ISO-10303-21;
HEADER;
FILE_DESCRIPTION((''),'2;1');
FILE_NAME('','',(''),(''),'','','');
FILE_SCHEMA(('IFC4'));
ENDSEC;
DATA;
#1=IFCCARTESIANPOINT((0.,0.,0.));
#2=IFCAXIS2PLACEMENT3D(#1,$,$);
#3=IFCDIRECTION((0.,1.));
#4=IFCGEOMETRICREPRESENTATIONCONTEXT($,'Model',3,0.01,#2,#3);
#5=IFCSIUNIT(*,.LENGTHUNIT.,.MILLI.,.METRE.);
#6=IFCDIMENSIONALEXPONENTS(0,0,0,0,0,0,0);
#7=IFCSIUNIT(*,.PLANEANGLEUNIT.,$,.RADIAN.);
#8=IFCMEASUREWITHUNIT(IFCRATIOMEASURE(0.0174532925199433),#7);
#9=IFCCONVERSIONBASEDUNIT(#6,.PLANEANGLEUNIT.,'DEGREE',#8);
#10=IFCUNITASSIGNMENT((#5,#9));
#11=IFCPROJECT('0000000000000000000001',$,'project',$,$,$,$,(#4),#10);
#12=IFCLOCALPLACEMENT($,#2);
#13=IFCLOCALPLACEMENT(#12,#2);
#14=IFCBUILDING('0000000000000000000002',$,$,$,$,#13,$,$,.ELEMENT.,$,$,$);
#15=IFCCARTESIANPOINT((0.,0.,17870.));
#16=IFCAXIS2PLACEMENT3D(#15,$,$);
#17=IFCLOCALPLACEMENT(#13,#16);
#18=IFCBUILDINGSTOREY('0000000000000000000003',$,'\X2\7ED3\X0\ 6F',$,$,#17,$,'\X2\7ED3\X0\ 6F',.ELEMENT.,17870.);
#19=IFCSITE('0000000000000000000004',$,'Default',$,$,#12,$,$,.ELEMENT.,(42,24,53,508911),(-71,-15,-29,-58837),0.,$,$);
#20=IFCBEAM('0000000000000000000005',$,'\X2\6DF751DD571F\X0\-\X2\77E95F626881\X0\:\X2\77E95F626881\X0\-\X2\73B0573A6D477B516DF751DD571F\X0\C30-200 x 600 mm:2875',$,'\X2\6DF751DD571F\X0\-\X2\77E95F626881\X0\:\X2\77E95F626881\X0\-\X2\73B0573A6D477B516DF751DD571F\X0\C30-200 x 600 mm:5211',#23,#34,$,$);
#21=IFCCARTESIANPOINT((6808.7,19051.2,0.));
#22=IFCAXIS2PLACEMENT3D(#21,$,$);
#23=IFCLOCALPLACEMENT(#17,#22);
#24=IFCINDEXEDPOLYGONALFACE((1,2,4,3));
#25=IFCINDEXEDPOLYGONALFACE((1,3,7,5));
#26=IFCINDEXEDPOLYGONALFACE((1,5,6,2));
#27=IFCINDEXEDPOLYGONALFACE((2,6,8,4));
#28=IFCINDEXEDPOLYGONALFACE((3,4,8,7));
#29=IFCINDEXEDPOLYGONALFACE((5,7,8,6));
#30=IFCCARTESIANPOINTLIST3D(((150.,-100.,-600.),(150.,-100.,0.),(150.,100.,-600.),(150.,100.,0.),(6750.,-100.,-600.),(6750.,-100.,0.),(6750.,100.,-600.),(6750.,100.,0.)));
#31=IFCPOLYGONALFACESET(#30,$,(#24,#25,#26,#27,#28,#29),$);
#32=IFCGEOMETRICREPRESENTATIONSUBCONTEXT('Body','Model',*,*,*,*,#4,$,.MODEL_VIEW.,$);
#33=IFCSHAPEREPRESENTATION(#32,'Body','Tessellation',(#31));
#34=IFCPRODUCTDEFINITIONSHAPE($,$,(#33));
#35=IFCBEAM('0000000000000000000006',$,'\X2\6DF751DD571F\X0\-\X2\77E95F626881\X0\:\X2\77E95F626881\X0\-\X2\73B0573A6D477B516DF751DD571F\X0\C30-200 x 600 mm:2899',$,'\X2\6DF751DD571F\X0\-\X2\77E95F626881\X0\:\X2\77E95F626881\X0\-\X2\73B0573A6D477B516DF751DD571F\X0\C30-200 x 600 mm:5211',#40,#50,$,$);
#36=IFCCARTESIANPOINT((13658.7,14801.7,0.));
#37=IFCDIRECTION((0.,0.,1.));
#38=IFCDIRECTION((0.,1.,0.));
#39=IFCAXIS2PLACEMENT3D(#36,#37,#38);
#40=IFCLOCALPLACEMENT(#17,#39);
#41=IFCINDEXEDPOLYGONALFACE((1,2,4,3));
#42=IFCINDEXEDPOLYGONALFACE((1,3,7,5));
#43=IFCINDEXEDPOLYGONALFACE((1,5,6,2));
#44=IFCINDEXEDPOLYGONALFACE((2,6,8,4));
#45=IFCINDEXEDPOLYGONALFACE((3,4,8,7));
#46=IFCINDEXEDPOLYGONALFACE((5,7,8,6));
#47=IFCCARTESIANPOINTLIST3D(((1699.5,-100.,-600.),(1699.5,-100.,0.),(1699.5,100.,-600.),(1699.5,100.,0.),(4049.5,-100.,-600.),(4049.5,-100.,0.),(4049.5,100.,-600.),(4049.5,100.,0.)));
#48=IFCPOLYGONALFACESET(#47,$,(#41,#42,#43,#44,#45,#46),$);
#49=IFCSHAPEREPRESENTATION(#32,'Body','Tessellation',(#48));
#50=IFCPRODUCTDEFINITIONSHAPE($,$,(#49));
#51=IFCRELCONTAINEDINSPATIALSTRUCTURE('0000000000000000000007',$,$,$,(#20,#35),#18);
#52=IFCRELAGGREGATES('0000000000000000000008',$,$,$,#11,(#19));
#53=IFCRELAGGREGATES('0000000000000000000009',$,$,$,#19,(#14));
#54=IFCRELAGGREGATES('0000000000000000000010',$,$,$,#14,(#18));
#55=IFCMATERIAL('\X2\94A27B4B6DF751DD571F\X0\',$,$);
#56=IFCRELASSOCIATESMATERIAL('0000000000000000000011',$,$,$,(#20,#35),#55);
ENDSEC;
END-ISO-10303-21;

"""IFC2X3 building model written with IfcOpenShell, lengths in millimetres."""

from ifc_helpers import new_model, entity, si_unit, converted_unit, direction, frame, frame_2d, origin, place, context, subcontext, project, spatial, rectangle, extrude, material, element, save


model = new_model("IFC2X3")

# Units and contexts
model_context = context("Model", 3, precision=0.01, world=origin(), true_north=direction((0.0, 1.0)))
body_context = subcontext(model_context, "Body", "Model", "MODEL_VIEW")
ifc_project = project(units=[si_unit("LENGTHUNIT", "METRE", prefix="MILLI"), converted_unit("PLANEANGLEUNIT", "DEGREE", entity("IfcRatioMeasure", 0.0174532925199433), si_unit("PLANEANGLEUNIT", "RADIAN"), dimensions=[0, 0, 0, 0, 0, 0, 0])], contexts=[model_context])

# Site, building, storey
site_placement = place(None, origin())
site = spatial("IfcSite", under=ifc_project, at=site_placement, Name="Default", CompositionType="ELEMENT", RefLatitude=(42, 24, 53, 508911), RefLongitude=(-71, -15, -29, -58837), RefElevation=0.0)
building_placement = place(site_placement, origin())
building = spatial("IfcBuilding", under=site, at=building_placement, CompositionType="ELEMENT")
storey_placement = place(building_placement, frame((0.0, 0.0, 17870.0)))
storey = spatial("IfcBuildingStorey", under=building, at=storey_placement, Name="结 6F", LongName="结 6F", CompositionType="ELEMENT", Elevation=17870.0)

# Beams
ifc_material = material(Name="钢筋混凝土")
beam_1_placement = place(storey_placement, frame((6808.7, 19051.2, 0.0)))
element("IfcBeam", 1, at=beam_1_placement, inside=storey, material=ifc_material, Name="混凝土-矩形梁:矩形梁-现场浇筑混凝土C30-200 x 600 mm:2875", ObjectType="混凝土-矩形梁:矩形梁-现场浇筑混凝土C30-200 x 600 mm:5211", context=body_context, shape_type="SweptSolid", body=[
    extrude(rectangle(XDim=600.0, YDim=200.0, at=frame_2d((0.0, 0.0), x_axis=(1.0, 0.0))), frame((150.0, 0.0, -300.0), z_axis=(1.0, 0.0, 0.0), x_axis=(0.0, 0.0, -1.0)), (0.0, 0.0, 1.0), 6600.0),
])
beam_2_placement = place(storey_placement, frame((13658.7, 14801.7, 0.0), z_axis=(0.0, 0.0, 1.0), x_axis=(0.0, 1.0, 0.0)))
element("IfcBeam", 2, at=beam_2_placement, inside=storey, material=ifc_material, Name="混凝土-矩形梁:矩形梁-现场浇筑混凝土C30-200 x 600 mm:2899", ObjectType="混凝土-矩形梁:矩形梁-现场浇筑混凝土C30-200 x 600 mm:5211", context=body_context, shape_type="SweptSolid", body=[
    extrude(rectangle(XDim=600.0, YDim=200.0, at=frame_2d((0.0, 0.0), x_axis=(1.0, 0.0))), frame((1699.5, 0.0, -300.0), z_axis=(1.0, 0.0, 0.0), x_axis=(0.0, 0.0, -1.0)), (0.0, 0.0, 1.0), 2350.0),
])

save(model, "model.ifc")
